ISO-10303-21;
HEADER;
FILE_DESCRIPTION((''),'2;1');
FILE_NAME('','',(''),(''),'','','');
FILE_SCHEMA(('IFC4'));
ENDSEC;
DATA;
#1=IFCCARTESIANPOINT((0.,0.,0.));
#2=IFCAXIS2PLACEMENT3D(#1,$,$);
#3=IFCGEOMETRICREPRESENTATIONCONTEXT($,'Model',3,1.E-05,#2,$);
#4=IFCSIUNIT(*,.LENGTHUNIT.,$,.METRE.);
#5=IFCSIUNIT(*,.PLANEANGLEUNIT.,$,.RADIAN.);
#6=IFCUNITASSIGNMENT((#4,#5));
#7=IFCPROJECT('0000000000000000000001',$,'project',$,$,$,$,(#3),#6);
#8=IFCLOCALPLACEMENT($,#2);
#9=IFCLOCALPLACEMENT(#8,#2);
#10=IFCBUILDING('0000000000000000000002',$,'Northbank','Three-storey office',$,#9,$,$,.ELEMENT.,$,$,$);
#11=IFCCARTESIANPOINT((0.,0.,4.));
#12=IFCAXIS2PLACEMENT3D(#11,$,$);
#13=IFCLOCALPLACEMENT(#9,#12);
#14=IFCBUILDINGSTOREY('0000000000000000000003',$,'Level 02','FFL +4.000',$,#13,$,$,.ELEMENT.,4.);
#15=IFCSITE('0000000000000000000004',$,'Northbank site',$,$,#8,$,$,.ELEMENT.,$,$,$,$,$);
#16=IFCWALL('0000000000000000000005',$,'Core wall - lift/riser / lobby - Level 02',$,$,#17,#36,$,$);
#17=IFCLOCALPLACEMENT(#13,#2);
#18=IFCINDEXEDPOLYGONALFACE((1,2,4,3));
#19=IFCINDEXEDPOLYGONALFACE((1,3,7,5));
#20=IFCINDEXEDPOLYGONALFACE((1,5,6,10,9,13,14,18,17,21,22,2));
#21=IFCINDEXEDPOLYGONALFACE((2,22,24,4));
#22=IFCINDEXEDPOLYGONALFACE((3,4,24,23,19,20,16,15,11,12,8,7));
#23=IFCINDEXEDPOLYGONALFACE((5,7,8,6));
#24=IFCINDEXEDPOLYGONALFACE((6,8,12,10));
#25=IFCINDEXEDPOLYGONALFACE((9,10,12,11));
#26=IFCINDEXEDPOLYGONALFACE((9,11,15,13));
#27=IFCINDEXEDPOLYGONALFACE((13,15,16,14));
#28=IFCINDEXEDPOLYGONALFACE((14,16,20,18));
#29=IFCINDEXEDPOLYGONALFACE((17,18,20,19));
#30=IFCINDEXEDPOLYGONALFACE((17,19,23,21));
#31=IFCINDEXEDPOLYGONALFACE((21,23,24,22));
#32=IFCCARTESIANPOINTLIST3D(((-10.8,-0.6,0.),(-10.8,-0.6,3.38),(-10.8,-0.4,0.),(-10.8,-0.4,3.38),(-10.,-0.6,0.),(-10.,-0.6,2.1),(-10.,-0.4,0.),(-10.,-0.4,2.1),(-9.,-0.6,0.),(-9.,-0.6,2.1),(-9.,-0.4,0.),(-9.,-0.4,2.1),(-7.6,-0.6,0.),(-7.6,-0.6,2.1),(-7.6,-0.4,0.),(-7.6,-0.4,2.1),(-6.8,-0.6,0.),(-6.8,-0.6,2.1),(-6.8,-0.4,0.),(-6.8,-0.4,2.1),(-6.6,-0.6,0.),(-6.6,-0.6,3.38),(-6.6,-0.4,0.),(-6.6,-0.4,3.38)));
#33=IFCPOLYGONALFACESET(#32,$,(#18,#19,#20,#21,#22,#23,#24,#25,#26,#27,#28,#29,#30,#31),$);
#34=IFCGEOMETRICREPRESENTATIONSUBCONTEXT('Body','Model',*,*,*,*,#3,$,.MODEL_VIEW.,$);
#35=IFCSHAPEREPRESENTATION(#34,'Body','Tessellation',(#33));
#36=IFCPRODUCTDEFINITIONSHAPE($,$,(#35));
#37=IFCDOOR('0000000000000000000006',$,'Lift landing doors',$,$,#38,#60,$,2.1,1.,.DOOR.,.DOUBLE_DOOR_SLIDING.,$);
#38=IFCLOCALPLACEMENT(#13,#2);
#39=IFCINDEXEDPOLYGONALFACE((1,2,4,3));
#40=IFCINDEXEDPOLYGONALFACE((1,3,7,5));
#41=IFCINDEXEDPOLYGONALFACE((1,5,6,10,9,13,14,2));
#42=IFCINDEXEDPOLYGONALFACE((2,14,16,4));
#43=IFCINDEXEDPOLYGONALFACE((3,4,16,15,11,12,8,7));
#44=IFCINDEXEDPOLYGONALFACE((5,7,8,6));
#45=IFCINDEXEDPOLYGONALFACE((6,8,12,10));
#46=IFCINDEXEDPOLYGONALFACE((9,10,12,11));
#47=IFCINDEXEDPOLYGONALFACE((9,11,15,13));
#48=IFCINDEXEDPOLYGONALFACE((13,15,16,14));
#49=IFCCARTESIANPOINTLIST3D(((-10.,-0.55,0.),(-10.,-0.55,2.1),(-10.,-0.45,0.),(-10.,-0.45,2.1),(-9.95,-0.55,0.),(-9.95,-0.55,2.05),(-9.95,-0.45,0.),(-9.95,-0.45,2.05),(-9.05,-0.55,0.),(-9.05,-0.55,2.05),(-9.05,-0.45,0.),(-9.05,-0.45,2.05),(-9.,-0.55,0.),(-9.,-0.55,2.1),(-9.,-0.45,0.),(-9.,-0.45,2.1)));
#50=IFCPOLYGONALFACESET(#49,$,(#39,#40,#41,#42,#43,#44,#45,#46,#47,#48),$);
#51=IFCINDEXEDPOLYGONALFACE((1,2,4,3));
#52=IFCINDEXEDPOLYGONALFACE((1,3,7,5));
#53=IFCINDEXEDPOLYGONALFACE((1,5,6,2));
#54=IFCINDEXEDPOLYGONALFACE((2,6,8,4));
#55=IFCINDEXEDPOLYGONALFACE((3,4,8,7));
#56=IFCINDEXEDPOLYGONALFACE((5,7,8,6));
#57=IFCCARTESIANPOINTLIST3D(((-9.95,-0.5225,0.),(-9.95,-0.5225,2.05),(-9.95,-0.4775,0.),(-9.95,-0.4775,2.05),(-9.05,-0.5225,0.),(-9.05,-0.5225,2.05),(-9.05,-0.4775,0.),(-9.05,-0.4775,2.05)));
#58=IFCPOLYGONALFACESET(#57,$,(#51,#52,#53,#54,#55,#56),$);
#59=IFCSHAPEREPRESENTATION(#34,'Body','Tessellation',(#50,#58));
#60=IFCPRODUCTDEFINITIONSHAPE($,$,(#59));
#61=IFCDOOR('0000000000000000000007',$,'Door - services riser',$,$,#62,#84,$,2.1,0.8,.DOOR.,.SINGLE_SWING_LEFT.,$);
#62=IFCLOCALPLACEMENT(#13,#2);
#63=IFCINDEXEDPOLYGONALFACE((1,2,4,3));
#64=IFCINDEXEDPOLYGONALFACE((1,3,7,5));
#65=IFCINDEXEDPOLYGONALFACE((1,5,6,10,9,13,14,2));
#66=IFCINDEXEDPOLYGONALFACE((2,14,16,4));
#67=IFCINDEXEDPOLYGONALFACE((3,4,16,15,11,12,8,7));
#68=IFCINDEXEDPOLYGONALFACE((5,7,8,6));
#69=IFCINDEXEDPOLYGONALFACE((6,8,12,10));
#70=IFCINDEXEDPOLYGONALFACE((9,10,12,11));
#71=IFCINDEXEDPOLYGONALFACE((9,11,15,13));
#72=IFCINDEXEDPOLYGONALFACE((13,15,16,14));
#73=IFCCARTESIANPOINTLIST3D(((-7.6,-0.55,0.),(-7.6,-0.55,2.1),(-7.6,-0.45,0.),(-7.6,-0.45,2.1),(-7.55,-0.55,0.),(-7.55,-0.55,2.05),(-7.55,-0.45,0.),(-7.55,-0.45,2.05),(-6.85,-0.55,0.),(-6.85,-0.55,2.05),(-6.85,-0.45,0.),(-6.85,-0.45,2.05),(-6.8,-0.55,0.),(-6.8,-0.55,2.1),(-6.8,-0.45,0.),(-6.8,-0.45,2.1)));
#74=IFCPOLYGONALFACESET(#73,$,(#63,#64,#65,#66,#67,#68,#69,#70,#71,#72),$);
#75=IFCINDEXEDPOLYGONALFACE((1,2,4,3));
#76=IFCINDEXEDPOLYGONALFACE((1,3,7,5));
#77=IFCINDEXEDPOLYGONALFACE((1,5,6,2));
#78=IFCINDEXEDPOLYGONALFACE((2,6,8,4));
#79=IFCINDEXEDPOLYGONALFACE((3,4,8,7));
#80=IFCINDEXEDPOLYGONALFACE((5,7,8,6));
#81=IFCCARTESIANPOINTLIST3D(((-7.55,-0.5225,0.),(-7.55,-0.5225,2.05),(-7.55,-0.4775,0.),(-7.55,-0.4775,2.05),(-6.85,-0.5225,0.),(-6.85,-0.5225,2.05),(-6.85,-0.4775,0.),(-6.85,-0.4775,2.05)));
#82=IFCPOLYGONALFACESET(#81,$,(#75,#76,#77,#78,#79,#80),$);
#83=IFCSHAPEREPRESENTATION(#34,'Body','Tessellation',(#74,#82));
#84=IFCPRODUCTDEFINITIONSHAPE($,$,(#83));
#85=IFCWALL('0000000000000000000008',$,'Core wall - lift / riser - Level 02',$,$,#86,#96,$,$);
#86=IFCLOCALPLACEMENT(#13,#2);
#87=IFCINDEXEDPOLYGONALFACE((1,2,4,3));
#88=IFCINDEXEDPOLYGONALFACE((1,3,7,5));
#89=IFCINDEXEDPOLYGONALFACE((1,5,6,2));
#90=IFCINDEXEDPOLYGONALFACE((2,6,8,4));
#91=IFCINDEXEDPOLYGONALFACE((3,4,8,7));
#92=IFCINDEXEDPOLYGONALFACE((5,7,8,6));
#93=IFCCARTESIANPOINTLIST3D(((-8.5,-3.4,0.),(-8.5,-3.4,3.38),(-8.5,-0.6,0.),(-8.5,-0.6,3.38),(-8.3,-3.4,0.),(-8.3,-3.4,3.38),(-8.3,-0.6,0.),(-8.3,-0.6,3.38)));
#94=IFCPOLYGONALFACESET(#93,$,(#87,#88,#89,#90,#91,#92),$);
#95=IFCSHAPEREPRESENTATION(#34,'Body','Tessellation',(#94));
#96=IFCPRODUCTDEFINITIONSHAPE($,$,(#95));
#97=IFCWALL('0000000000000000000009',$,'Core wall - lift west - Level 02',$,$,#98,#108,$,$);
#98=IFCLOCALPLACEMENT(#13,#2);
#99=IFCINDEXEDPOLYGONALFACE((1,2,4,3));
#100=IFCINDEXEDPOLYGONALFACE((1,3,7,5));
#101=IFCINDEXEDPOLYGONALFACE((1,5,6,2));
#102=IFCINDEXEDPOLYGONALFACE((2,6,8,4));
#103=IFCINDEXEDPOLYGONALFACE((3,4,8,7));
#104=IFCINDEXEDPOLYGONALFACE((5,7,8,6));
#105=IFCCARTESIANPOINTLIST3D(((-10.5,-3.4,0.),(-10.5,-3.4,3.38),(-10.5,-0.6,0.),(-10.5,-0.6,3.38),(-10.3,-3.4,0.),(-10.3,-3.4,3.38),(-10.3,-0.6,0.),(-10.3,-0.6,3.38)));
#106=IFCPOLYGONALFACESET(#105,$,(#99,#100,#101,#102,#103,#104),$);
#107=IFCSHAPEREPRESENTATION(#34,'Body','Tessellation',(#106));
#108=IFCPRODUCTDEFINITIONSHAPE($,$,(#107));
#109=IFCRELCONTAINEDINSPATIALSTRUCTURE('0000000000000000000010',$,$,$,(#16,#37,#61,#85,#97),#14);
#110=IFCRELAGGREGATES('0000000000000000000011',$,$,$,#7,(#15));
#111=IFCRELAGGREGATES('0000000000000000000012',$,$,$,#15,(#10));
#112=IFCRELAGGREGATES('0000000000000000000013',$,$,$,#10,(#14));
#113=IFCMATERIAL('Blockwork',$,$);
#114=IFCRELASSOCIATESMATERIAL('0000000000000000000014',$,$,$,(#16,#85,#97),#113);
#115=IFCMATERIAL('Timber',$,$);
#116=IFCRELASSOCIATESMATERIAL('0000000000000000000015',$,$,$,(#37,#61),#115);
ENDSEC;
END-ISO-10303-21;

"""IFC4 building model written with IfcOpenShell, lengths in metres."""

from ifc_helpers import new_model, si_unit, frame, origin, place, context, subcontext, project, spatial, polyline, outline, extrude, material, element, fill, save


model = new_model("IFC4")

# Units and contexts
model_context = context("Model", 3, precision=1e-05, world=origin())
body_context = subcontext(model_context, "Body", "Model", "MODEL_VIEW")
ifc_project = project(units=[si_unit("LENGTHUNIT", "METRE"), si_unit("PLANEANGLEUNIT", "RADIAN")], contexts=[model_context])

# Site, building, storey
site_placement = place(None, origin())
site = spatial("IfcSite", under=ifc_project, at=site_placement, Name="Northbank site", CompositionType="ELEMENT")
building_placement = place(site_placement, origin())
building = spatial("IfcBuilding", under=site, at=building_placement, Name="Northbank", Description="Three-storey office", CompositionType="ELEMENT")
storey_placement = place(building_placement, frame((0.0, 0.0, 4.0)))
storey = spatial("IfcBuildingStorey", under=building, at=storey_placement, Name="Level 02", Description="FFL +4.000", CompositionType="ELEMENT", Elevation=4.0)

# Shared definitions
ifc_material_1 = material(Name="Blockwork")
ifc_material_2 = material(Name="Timber")

# Wall, openings, doors
wall_1_placement = place(storey_placement, frame((0.0, 0.0, -4.0)))
wall_1 = element("IfcWall", 1, at=wall_1_placement, inside=storey, material=ifc_material_1, Name="Core wall - lift/riser / lobby - Level 02", context=body_context, shape_type="SweptSolid", body=[
    extrude(outline(polyline([(0.0, 0.0), (0.8, 0.0), (0.8, 2.1), (1.8, 2.1), (1.8, 0.0), (3.2, 0.0), (3.2, 2.1), (4.0, 2.1), (4.0, 0.0), (4.2, 0.0), (4.2, 3.38), (0.0, 3.38), (0.0, 0.0)])), frame((-10.8, -0.4, 4.0), z_axis=(0.0, -1.0, 0.0), x_axis=(1.0, 0.0, 0.0)), (0.0, 0.0, 1.0), 0.2),
])
opening_1_placement = place(storey_placement, frame((0.0, 0.0, -4.0)))
opening_1 = element("IfcOpeningElement", 2, at=opening_1_placement, cuts=wall_1, PredefinedType="OPENING", context=body_context, shape_type="SweptSolid", body=[
    extrude(outline(polyline([(0.0, 0.0), (1.0, 0.0), (1.0, 2.1), (0.0, 2.1), (0.0, 0.0)])), frame((-10.0, -0.35, 4.0), z_axis=(0.0, -1.0, 0.0), x_axis=(1.0, 0.0, 0.0)), (0.0, 0.0, 1.0), 0.3),
])
opening_2_placement = place(storey_placement, frame((0.0, 0.0, -4.0)))
opening_2 = element("IfcOpeningElement", 3, at=opening_2_placement, cuts=wall_1, PredefinedType="OPENING", context=body_context, shape_type="SweptSolid", body=[
    extrude(outline(polyline([(0.0, 0.0), (0.8, 0.0), (0.8, 2.1), (0.0, 2.1), (0.0, 0.0)])), frame((-7.6, -0.35, 4.0), z_axis=(0.0, -1.0, 0.0), x_axis=(1.0, 0.0, 0.0)), (0.0, 0.0, 1.0), 0.3),
])
door_1_placement = place(storey_placement, frame((0.0, 0.0, -4.0)))
door_1 = element("IfcDoor", 4, at=door_1_placement, inside=storey, material=ifc_material_2, Name="Lift landing doors", OperationType="DOUBLE_DOOR_SLIDING", OverallHeight=2.1, OverallWidth=1.0, PredefinedType="DOOR", context=body_context, shape_type="SweptSolid", body=[
    extrude(outline(polyline([(0.0, 0.0), (0.05, 0.0), (0.05, 2.05), (0.95, 2.05), (0.95, 0.0), (1.0, 0.0), (1.0, 2.1), (0.0, 2.1), (0.0, 0.0)])), frame((-10.0, -0.45, 4.0), z_axis=(0.0, -1.0, 0.0), x_axis=(1.0, 0.0, 0.0)), (0.0, 0.0, 1.0), 0.1),
    extrude(outline(polyline([(0.0, 0.0), (0.9, 0.0), (0.9, 2.05), (0.0, 2.05), (0.0, 0.0)])), frame((-9.95, -0.4775, 4.0), z_axis=(0.0, -1.0, 0.0), x_axis=(1.0, 0.0, 0.0)), (0.0, 0.0, 1.0), 0.045),
])
fill(opening_1, door_1)
door_2_placement = place(storey_placement, frame((0.0, 0.0, -4.0)))
door_2 = element("IfcDoor", 5, at=door_2_placement, inside=storey, material=ifc_material_2, Name="Door - services riser", OperationType="SINGLE_SWING_LEFT", OverallHeight=2.1, OverallWidth=0.8, PredefinedType="DOOR", context=body_context, shape_type="SweptSolid", body=[
    extrude(outline(polyline([(0.0, 0.0), (0.05, 0.0), (0.05, 2.05), (0.75, 2.05), (0.75, 0.0), (0.8, 0.0), (0.8, 2.1), (0.0, 2.1), (0.0, 0.0)])), frame((-7.6, -0.45, 4.0), z_axis=(0.0, -1.0, 0.0), x_axis=(1.0, 0.0, 0.0)), (0.0, 0.0, 1.0), 0.1),
    extrude(outline(polyline([(0.0, 0.0), (0.7, 0.0), (0.7, 2.05), (0.0, 2.05), (0.0, 0.0)])), frame((-7.55, -0.4775, 4.0), z_axis=(0.0, -1.0, 0.0), x_axis=(1.0, 0.0, 0.0)), (0.0, 0.0, 1.0), 0.045),
])
fill(opening_2, door_2)

# Walls
wall_2_placement = place(storey_placement, frame((0.0, 0.0, -4.0)))
element("IfcWall", 6, at=wall_2_placement, inside=storey, material=ifc_material_1, Name="Core wall - lift / riser - Level 02", context=body_context, shape_type="SweptSolid", body=[
    extrude(outline(polyline([(0.0, 0.0), (2.8, 0.0), (2.8, 3.38), (0.0, 3.38), (0.0, 0.0)])), frame((-8.5, -3.4, 4.0), z_axis=(1.0, 0.0, 0.0), x_axis=(0.0, 1.0, 0.0)), (0.0, 0.0, 1.0), 0.2),
])
wall_3_placement = place(storey_placement, frame((0.0, 0.0, -4.0)))
element("IfcWall", 7, at=wall_3_placement, inside=storey, material=ifc_material_1, Name="Core wall - lift west - Level 02", context=body_context, shape_type="SweptSolid", body=[
    extrude(outline(polyline([(0.0, 0.0), (2.8, 0.0), (2.8, 3.38), (0.0, 3.38), (0.0, 0.0)])), frame((-10.5, -3.4, 4.0), z_axis=(1.0, 0.0, 0.0), x_axis=(0.0, 1.0, 0.0)), (0.0, 0.0, 1.0), 0.2),
])

save(model, "model.ifc")
